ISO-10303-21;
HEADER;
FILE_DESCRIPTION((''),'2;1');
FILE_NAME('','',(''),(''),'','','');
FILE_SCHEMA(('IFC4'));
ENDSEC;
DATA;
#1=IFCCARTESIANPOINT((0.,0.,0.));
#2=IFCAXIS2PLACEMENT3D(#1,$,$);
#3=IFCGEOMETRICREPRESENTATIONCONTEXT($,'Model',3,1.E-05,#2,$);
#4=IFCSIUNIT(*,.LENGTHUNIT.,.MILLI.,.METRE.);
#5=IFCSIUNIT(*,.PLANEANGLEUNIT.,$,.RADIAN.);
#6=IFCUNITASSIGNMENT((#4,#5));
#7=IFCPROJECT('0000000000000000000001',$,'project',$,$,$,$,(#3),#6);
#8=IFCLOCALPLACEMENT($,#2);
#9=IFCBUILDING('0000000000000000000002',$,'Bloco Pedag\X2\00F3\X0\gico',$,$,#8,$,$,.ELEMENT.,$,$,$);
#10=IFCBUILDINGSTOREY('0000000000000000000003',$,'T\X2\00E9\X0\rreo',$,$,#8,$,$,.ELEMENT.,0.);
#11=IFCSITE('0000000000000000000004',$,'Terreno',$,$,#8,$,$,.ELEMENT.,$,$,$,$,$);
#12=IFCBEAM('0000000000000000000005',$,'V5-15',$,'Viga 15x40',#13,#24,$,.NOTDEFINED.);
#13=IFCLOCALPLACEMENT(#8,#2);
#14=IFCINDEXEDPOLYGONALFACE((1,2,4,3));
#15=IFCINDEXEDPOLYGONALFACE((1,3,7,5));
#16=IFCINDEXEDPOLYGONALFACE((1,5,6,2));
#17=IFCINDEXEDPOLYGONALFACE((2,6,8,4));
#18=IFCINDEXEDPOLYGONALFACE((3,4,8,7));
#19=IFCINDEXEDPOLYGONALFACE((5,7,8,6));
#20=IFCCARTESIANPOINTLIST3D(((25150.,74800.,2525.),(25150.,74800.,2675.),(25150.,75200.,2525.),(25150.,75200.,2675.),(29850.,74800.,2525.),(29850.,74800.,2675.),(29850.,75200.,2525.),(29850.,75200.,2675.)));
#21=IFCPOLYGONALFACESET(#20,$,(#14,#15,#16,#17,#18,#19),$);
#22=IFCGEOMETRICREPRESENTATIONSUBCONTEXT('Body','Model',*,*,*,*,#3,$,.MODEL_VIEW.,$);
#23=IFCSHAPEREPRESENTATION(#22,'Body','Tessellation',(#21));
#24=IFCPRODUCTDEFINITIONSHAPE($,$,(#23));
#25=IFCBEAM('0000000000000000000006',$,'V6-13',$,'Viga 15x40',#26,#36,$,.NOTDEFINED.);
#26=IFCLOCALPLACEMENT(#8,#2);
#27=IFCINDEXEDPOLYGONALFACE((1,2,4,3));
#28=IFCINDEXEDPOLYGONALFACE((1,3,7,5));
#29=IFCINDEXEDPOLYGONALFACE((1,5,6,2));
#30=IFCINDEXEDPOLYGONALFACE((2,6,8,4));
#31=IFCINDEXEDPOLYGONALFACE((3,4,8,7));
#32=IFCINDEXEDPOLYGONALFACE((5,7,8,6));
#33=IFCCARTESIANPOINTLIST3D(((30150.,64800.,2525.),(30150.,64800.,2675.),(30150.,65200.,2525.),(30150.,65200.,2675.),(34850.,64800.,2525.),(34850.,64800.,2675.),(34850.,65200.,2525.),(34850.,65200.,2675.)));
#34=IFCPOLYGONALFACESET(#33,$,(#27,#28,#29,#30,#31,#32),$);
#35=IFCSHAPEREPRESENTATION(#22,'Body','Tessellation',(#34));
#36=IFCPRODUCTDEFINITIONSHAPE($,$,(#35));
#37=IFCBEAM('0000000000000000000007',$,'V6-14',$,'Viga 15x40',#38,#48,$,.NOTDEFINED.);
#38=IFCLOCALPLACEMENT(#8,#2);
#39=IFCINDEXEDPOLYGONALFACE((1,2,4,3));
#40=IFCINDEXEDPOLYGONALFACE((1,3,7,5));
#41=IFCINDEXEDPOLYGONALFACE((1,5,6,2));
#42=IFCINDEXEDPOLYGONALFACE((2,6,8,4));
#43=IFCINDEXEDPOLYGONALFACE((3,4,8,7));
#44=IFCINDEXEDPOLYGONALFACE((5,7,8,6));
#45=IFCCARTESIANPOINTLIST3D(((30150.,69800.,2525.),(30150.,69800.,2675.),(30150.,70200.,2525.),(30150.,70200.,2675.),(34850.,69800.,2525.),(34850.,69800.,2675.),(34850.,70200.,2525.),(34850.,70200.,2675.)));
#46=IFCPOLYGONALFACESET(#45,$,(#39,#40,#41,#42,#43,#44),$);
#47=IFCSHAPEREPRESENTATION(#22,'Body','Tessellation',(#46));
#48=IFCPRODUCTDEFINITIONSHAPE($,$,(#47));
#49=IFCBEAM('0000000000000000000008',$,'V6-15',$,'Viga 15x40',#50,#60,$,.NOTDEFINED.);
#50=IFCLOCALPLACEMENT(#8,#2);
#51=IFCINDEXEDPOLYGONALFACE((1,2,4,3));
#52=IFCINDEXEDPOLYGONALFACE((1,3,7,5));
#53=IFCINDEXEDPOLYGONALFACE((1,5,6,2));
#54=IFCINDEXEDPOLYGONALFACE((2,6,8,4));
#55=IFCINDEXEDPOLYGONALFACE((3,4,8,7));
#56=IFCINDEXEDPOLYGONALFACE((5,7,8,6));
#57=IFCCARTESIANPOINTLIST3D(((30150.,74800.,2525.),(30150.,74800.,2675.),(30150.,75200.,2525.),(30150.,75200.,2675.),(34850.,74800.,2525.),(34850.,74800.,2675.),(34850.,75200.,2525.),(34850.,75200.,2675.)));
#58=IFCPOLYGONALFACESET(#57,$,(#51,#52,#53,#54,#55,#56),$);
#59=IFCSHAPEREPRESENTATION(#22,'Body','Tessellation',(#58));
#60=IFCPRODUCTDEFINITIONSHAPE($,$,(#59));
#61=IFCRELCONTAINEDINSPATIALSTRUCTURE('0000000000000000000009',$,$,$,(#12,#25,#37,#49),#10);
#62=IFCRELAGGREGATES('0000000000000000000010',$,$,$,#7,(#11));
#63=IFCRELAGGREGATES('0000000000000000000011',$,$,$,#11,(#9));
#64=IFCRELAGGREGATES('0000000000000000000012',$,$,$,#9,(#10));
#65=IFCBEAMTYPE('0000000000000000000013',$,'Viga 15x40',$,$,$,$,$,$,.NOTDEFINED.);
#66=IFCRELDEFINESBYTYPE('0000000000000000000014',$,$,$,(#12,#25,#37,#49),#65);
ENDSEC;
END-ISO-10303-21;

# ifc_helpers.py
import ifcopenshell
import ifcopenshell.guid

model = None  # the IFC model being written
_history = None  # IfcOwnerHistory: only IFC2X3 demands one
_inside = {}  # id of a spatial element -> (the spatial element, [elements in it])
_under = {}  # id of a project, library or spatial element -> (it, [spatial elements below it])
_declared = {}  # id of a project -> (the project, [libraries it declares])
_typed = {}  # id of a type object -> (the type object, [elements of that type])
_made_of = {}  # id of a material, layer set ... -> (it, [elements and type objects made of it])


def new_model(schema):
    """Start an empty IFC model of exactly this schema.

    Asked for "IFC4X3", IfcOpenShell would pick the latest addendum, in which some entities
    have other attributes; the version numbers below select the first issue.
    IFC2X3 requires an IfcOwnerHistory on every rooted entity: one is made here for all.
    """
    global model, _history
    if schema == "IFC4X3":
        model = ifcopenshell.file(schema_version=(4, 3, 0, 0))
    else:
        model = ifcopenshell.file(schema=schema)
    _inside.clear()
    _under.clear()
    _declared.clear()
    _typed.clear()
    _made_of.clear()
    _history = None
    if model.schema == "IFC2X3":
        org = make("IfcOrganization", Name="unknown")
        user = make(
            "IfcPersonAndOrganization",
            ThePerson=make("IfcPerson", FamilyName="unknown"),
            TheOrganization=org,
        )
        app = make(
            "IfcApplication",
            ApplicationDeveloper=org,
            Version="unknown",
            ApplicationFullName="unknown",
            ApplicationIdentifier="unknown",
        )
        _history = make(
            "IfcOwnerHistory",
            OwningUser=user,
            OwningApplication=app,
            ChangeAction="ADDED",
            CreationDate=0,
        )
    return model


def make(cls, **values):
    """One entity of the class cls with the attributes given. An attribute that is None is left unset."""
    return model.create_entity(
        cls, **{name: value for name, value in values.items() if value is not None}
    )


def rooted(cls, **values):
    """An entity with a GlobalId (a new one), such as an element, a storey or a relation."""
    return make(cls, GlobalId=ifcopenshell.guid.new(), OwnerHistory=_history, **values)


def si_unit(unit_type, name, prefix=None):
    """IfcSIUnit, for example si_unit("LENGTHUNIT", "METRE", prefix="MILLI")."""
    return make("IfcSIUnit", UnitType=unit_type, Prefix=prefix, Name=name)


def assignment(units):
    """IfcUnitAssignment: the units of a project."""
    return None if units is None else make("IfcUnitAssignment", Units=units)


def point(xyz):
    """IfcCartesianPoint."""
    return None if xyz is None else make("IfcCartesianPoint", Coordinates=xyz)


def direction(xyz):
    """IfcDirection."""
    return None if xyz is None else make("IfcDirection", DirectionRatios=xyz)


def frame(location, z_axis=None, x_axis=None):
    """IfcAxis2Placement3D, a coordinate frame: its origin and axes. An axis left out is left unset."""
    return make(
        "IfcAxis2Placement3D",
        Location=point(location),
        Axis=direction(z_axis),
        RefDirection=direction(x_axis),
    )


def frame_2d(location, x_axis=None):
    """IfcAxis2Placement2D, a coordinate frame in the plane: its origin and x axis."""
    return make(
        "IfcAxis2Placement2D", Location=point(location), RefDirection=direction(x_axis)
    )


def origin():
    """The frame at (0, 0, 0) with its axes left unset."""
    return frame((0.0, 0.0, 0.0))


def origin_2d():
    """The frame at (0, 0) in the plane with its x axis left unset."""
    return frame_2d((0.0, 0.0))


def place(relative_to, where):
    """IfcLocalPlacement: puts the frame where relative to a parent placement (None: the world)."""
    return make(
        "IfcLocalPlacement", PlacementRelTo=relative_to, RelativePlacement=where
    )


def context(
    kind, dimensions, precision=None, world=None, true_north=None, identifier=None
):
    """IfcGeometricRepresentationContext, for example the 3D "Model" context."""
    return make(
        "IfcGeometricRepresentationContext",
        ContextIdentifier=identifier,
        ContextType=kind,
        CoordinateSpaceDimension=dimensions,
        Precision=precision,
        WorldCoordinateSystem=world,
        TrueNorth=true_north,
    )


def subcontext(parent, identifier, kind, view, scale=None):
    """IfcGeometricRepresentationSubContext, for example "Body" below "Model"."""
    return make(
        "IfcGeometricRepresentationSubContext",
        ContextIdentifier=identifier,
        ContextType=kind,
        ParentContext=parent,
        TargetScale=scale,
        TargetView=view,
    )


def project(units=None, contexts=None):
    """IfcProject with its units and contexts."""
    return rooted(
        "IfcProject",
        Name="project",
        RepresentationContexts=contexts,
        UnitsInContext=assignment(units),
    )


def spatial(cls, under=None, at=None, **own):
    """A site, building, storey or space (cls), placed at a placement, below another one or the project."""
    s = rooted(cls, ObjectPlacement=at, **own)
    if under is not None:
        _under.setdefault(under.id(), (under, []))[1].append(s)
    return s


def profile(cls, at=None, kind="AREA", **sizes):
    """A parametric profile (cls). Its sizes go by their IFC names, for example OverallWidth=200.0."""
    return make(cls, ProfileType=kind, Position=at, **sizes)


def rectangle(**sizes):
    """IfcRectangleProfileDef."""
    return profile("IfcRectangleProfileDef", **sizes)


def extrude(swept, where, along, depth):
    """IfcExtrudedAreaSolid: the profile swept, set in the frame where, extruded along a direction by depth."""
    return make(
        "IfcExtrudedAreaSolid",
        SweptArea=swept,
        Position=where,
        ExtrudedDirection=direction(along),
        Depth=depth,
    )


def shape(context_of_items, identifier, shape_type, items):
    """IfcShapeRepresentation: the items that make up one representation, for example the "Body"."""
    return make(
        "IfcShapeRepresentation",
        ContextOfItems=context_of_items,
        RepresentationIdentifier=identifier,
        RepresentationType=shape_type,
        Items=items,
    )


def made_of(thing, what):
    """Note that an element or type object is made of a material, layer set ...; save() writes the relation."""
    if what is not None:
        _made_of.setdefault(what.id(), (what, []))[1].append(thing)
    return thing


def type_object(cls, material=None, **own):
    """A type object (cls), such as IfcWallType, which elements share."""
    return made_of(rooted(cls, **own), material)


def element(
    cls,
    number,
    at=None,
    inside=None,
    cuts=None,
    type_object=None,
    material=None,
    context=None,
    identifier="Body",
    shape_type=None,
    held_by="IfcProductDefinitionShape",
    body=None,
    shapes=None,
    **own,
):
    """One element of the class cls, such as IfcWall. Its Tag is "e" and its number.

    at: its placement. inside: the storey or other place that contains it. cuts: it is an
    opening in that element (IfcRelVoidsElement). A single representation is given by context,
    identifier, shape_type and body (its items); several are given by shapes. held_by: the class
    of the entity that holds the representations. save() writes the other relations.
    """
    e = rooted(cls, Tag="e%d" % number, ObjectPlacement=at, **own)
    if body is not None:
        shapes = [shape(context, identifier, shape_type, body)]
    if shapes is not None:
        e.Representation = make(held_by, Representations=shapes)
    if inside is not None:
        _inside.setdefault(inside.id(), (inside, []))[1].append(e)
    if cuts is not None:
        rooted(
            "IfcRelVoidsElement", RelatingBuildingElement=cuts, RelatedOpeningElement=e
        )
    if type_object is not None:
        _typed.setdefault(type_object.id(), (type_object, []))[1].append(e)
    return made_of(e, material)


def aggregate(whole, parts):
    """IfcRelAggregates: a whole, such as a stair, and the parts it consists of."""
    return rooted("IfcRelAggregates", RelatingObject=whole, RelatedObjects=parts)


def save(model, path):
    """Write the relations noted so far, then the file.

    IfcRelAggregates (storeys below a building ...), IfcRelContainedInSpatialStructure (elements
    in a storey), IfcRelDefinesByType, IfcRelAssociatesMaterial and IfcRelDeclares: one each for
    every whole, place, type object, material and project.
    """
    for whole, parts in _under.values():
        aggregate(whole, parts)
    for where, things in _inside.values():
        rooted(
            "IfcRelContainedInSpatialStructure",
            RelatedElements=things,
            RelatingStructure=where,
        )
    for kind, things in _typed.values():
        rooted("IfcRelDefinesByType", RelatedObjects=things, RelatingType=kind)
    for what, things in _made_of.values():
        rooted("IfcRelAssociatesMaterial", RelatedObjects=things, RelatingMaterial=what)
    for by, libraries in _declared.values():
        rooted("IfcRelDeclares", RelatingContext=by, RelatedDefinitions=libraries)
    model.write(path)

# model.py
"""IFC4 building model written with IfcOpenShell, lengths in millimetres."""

from ifc_helpers import new_model, si_unit, frame, origin, origin_2d, place, context, subcontext, project, spatial, rectangle, extrude, type_object, element, save


model = new_model("IFC4")

# Units and contexts
model_context = context("Model", 3, precision=1e-05, world=origin())
body_context = subcontext(model_context, "Body", "Model", "MODEL_VIEW")
ifc_project = project(units=[si_unit("LENGTHUNIT", "METRE", prefix="MILLI"), si_unit("PLANEANGLEUNIT", "RADIAN")], contexts=[model_context])

# Site, building, storey
placement = place(None, origin())
site = spatial("IfcSite", under=ifc_project, at=placement, Name="Terreno", CompositionType="ELEMENT")
building = spatial("IfcBuilding", under=site, at=placement, Name="Bloco Pedagógico", CompositionType="ELEMENT")
storey = spatial("IfcBuildingStorey", under=building, at=placement, Name="Térreo", CompositionType="ELEMENT", Elevation=0.0)

# Beams
beam_type = type_object("IfcBeamType", Name="Viga 15x40", PredefinedType="NOTDEFINED")
for number, where, z_axis, x_axis, name in (
    (1, (25150.0, 75000.0, 2600.0), (1.0, 0.0, 0.0), (0.0, 1.0, 0.0), "V5-15"),
    (2, (30150.0, 65000.0, 2600.0), (1.0, 0.0, 0.0), (0.0, 1.0, 0.0), "V6-13"),
    (3, (30150.0, 70000.0, 2600.0), (1.0, 0.0, 0.0), (0.0, 1.0, 0.0), "V6-14"),
    (4, (30150.0, 75000.0, 2600.0), (1.0, 0.0, 0.0), (0.0, 1.0, 0.0), "V6-15"),
):
    element("IfcBeam", number, at=place(None, frame(where, z_axis=z_axis, x_axis=x_axis)), inside=storey, type_object=beam_type, Name=name, ObjectType="Viga 15x40", PredefinedType="NOTDEFINED", context=body_context, shape_type="SweptSolid", body=[
        extrude(rectangle(XDim=400.0, YDim=150.0, at=origin_2d()), None, (0.0, 0.0, 1.0), 4700.0),
    ])

save(model, "model.ifc")
